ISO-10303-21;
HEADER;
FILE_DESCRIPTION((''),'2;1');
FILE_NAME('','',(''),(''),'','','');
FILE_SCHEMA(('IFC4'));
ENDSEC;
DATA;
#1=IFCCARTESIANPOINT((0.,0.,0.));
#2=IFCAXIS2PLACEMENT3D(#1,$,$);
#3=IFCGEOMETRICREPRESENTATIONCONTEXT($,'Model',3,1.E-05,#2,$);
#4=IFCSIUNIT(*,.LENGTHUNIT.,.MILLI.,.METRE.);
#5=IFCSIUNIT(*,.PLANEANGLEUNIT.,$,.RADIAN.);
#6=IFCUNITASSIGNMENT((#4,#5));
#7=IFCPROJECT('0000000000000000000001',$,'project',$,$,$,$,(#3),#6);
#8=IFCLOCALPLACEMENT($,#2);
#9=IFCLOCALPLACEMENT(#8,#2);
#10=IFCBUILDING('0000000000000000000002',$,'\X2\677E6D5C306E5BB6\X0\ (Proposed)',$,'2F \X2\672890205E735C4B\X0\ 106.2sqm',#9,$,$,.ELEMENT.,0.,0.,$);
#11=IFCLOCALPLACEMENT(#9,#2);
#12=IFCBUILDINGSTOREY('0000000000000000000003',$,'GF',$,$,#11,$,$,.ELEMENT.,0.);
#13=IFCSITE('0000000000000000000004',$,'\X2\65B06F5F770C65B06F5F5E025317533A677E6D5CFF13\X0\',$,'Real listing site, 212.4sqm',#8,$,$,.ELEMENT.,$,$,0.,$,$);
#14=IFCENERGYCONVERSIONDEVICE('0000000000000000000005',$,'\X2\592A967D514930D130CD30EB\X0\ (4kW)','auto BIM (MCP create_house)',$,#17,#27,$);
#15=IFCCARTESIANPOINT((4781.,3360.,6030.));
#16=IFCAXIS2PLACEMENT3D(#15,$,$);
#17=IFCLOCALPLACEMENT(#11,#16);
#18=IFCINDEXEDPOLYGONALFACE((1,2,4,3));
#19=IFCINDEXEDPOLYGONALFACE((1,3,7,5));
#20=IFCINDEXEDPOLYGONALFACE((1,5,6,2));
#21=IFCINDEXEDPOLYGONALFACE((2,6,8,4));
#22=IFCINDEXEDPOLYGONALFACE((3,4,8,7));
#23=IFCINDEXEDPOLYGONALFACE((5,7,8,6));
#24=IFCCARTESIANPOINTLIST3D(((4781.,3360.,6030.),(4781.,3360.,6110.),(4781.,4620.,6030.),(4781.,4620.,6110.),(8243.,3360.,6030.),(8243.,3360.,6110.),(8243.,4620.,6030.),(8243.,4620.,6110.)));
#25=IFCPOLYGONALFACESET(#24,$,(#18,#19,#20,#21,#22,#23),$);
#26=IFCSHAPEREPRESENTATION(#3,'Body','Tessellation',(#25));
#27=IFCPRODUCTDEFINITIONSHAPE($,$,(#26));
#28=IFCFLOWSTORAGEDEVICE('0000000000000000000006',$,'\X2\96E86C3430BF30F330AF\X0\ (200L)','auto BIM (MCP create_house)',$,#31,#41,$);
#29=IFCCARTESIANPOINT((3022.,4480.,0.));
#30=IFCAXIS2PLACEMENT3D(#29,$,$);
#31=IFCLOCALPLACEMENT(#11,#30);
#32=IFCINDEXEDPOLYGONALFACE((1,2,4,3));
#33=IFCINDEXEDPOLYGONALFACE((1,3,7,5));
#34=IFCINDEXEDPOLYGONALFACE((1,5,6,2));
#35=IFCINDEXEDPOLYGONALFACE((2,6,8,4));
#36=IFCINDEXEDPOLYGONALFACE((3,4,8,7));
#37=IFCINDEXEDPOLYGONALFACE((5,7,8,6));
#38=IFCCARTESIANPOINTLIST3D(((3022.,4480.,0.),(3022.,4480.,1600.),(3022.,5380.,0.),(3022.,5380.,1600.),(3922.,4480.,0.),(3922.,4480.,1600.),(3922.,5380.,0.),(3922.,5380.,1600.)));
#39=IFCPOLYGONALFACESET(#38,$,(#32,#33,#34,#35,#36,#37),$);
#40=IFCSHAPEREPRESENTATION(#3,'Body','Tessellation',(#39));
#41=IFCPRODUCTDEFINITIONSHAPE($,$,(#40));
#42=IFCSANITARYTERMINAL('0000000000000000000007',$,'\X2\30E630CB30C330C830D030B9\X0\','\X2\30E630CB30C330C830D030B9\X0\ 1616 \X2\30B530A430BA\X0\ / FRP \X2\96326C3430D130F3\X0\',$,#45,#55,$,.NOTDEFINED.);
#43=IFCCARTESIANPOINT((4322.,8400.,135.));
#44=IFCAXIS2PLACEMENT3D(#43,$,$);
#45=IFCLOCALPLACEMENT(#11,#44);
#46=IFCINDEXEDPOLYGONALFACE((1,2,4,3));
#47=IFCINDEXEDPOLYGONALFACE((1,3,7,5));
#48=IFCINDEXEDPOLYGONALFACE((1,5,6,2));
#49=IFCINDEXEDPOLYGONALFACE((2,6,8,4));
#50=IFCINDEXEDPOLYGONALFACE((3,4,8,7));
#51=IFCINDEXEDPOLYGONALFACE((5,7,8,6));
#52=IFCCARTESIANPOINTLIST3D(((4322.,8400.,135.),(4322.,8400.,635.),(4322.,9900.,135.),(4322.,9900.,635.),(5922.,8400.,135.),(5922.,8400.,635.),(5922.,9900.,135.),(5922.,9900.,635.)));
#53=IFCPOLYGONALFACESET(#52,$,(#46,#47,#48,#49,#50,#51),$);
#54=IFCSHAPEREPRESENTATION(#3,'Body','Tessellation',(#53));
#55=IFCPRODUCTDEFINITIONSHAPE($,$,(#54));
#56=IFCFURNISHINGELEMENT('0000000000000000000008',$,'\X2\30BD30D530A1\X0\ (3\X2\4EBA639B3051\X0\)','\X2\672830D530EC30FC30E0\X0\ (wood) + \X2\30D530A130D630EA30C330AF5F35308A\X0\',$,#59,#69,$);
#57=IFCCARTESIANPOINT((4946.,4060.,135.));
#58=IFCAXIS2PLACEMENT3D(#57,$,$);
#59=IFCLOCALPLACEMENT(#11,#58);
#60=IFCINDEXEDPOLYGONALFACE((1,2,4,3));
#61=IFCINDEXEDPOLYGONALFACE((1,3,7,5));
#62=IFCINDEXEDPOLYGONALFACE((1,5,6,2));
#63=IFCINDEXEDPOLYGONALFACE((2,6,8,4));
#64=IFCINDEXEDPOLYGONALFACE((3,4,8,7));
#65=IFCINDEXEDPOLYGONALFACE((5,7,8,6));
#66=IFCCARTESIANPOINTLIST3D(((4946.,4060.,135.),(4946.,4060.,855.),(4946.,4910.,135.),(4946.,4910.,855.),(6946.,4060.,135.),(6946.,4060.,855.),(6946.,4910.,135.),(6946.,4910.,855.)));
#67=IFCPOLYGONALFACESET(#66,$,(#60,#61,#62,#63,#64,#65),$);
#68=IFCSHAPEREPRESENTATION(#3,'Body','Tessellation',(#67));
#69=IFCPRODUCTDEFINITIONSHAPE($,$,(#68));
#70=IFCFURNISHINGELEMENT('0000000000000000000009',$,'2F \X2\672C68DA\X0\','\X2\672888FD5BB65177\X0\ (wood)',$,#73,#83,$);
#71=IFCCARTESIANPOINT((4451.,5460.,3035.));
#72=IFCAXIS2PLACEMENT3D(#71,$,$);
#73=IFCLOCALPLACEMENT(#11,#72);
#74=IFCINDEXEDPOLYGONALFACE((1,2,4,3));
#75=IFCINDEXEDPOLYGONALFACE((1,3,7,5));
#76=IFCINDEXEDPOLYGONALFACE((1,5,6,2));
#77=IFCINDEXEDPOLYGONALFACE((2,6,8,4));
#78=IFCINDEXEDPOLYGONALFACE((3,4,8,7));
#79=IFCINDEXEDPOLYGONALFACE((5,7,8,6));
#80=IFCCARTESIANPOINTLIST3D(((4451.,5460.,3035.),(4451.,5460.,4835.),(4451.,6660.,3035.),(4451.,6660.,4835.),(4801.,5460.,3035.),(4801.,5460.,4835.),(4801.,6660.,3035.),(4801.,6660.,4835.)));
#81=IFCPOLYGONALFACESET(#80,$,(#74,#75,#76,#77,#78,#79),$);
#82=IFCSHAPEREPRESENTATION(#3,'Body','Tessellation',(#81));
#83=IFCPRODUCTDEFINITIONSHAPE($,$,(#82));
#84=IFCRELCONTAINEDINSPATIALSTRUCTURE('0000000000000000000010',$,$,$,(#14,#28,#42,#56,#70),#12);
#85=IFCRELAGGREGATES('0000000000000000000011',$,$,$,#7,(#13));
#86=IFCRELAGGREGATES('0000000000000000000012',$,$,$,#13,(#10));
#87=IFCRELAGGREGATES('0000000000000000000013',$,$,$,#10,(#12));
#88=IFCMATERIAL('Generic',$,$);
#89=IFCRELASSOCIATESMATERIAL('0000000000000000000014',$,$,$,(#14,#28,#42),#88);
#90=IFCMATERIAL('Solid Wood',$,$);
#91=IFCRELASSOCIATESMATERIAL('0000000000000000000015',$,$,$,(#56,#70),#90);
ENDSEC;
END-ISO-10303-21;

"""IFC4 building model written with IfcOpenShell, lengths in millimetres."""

from ifc_helpers import new_model, si_unit, frame, frame_2d, origin, place, context, project, spatial, rectangle, extrude, material, element, save


model = new_model("IFC4")

# Units and contexts
model_context = context("Model", 3, precision=1e-05, world=origin())
ifc_project = project(units=[si_unit("LENGTHUNIT", "METRE", prefix="MILLI"), si_unit("PLANEANGLEUNIT", "RADIAN")], contexts=[model_context])

# Site, building, storey
site_placement = place(None, origin())
site = spatial("IfcSite", under=ifc_project, at=site_placement, Name="新潟県新潟市北区松浜３", ObjectType="Real listing site, 212.4sqm", CompositionType="ELEMENT", RefElevation=0.0)
building_placement = place(site_placement, origin())
building = spatial("IfcBuilding", under=site, at=building_placement, Name="松浜の家 (Proposed)", ObjectType="2F 木造平屋 106.2sqm", CompositionType="ELEMENT", ElevationOfRefHeight=0.0, ElevationOfTerrain=0.0)
storey_placement = place(building_placement, origin())
storey = spatial("IfcBuildingStorey", under=building, at=storey_placement, Name="GF", CompositionType="ELEMENT", Elevation=0.0)

# Shared definitions
ifc_material_1 = material(Name="Solid Wood")

# Energy conversion device
ifc_material_2 = material(Name="Generic")
energy_conversion_device_placement = place(storey_placement, frame((4781.0, 3360.0, 6030.0)))
element("IfcEnergyConversionDevice", 1, at=energy_conversion_device_placement, inside=storey, material=ifc_material_2, Name="太陽光パネル (4kW)", Description="auto BIM (MCP create_house)", context=model_context, shape_type="SweptSolid", body=[
    extrude(rectangle(XDim=3462.0, YDim=1260.0, at=frame_2d((1731.0, 630.0))), frame((4781.0, 3360.0, 6030.0)), (0.0, 0.0, 1.0), 80.0),
])

# Flow storage device
flow_storage_device_placement = place(storey_placement, frame((3022.0, 4480.0, 0.0)))
element("IfcFlowStorageDevice", 2, at=flow_storage_device_placement, inside=storey, material=ifc_material_2, Name="雨水タンク (200L)", Description="auto BIM (MCP create_house)", context=model_context, shape_type="SweptSolid", body=[
    extrude(rectangle(XDim=900.0, YDim=900.0, at=frame_2d((450.0, 450.0))), frame((3022.0, 4480.0, 0.0)), (0.0, 0.0, 1.0), 1600.0),
])

# Sanitary terminal
sanitary_terminal_placement = place(storey_placement, frame((4322.0, 8400.0, 135.0)))
element("IfcSanitaryTerminal", 3, at=sanitary_terminal_placement, inside=storey, material=ifc_material_2, Name="ユニットバス", Description="ユニットバス 1616 サイズ / FRP 防水パン", PredefinedType="NOTDEFINED", context=model_context, shape_type="SweptSolid", body=[
    extrude(rectangle(XDim=1600.0, YDim=1500.0, at=frame_2d((800.0, 750.0))), frame((4322.0, 8400.0, 135.0)), (0.0, 0.0, 1.0), 500.0),
])

# Furnishing elements
furnishing_1_placement = place(storey_placement, frame((4946.0, 4060.0, 135.0)))
element("IfcFurnishingElement", 4, at=furnishing_1_placement, inside=storey, material=ifc_material_1, Name="ソファ (3人掛け)", Description="木フレーム (wood) + ファブリック張り", context=model_context, shape_type="SweptSolid", body=[
    extrude(rectangle(XDim=2000.0, YDim=850.0, at=frame_2d((1000.0, 425.0))), frame((4946.0, 4060.0, 135.0)), (0.0, 0.0, 1.0), 720.0),
])
furnishing_2_placement = place(storey_placement, frame((4451.0, 5460.0, 3035.0)))
element("IfcFurnishingElement", 5, at=furnishing_2_placement, inside=storey, material=ifc_material_1, Name="2F 本棚", Description="木製家具 (wood)", context=model_context, shape_type="SweptSolid", body=[
    extrude(rectangle(XDim=350.0, YDim=1200.0, at=frame_2d((175.0, 600.0))), frame((4451.0, 5460.0, 3035.0)), (0.0, 0.0, 1.0), 1800.0),
])

save(model, "model.ifc")
